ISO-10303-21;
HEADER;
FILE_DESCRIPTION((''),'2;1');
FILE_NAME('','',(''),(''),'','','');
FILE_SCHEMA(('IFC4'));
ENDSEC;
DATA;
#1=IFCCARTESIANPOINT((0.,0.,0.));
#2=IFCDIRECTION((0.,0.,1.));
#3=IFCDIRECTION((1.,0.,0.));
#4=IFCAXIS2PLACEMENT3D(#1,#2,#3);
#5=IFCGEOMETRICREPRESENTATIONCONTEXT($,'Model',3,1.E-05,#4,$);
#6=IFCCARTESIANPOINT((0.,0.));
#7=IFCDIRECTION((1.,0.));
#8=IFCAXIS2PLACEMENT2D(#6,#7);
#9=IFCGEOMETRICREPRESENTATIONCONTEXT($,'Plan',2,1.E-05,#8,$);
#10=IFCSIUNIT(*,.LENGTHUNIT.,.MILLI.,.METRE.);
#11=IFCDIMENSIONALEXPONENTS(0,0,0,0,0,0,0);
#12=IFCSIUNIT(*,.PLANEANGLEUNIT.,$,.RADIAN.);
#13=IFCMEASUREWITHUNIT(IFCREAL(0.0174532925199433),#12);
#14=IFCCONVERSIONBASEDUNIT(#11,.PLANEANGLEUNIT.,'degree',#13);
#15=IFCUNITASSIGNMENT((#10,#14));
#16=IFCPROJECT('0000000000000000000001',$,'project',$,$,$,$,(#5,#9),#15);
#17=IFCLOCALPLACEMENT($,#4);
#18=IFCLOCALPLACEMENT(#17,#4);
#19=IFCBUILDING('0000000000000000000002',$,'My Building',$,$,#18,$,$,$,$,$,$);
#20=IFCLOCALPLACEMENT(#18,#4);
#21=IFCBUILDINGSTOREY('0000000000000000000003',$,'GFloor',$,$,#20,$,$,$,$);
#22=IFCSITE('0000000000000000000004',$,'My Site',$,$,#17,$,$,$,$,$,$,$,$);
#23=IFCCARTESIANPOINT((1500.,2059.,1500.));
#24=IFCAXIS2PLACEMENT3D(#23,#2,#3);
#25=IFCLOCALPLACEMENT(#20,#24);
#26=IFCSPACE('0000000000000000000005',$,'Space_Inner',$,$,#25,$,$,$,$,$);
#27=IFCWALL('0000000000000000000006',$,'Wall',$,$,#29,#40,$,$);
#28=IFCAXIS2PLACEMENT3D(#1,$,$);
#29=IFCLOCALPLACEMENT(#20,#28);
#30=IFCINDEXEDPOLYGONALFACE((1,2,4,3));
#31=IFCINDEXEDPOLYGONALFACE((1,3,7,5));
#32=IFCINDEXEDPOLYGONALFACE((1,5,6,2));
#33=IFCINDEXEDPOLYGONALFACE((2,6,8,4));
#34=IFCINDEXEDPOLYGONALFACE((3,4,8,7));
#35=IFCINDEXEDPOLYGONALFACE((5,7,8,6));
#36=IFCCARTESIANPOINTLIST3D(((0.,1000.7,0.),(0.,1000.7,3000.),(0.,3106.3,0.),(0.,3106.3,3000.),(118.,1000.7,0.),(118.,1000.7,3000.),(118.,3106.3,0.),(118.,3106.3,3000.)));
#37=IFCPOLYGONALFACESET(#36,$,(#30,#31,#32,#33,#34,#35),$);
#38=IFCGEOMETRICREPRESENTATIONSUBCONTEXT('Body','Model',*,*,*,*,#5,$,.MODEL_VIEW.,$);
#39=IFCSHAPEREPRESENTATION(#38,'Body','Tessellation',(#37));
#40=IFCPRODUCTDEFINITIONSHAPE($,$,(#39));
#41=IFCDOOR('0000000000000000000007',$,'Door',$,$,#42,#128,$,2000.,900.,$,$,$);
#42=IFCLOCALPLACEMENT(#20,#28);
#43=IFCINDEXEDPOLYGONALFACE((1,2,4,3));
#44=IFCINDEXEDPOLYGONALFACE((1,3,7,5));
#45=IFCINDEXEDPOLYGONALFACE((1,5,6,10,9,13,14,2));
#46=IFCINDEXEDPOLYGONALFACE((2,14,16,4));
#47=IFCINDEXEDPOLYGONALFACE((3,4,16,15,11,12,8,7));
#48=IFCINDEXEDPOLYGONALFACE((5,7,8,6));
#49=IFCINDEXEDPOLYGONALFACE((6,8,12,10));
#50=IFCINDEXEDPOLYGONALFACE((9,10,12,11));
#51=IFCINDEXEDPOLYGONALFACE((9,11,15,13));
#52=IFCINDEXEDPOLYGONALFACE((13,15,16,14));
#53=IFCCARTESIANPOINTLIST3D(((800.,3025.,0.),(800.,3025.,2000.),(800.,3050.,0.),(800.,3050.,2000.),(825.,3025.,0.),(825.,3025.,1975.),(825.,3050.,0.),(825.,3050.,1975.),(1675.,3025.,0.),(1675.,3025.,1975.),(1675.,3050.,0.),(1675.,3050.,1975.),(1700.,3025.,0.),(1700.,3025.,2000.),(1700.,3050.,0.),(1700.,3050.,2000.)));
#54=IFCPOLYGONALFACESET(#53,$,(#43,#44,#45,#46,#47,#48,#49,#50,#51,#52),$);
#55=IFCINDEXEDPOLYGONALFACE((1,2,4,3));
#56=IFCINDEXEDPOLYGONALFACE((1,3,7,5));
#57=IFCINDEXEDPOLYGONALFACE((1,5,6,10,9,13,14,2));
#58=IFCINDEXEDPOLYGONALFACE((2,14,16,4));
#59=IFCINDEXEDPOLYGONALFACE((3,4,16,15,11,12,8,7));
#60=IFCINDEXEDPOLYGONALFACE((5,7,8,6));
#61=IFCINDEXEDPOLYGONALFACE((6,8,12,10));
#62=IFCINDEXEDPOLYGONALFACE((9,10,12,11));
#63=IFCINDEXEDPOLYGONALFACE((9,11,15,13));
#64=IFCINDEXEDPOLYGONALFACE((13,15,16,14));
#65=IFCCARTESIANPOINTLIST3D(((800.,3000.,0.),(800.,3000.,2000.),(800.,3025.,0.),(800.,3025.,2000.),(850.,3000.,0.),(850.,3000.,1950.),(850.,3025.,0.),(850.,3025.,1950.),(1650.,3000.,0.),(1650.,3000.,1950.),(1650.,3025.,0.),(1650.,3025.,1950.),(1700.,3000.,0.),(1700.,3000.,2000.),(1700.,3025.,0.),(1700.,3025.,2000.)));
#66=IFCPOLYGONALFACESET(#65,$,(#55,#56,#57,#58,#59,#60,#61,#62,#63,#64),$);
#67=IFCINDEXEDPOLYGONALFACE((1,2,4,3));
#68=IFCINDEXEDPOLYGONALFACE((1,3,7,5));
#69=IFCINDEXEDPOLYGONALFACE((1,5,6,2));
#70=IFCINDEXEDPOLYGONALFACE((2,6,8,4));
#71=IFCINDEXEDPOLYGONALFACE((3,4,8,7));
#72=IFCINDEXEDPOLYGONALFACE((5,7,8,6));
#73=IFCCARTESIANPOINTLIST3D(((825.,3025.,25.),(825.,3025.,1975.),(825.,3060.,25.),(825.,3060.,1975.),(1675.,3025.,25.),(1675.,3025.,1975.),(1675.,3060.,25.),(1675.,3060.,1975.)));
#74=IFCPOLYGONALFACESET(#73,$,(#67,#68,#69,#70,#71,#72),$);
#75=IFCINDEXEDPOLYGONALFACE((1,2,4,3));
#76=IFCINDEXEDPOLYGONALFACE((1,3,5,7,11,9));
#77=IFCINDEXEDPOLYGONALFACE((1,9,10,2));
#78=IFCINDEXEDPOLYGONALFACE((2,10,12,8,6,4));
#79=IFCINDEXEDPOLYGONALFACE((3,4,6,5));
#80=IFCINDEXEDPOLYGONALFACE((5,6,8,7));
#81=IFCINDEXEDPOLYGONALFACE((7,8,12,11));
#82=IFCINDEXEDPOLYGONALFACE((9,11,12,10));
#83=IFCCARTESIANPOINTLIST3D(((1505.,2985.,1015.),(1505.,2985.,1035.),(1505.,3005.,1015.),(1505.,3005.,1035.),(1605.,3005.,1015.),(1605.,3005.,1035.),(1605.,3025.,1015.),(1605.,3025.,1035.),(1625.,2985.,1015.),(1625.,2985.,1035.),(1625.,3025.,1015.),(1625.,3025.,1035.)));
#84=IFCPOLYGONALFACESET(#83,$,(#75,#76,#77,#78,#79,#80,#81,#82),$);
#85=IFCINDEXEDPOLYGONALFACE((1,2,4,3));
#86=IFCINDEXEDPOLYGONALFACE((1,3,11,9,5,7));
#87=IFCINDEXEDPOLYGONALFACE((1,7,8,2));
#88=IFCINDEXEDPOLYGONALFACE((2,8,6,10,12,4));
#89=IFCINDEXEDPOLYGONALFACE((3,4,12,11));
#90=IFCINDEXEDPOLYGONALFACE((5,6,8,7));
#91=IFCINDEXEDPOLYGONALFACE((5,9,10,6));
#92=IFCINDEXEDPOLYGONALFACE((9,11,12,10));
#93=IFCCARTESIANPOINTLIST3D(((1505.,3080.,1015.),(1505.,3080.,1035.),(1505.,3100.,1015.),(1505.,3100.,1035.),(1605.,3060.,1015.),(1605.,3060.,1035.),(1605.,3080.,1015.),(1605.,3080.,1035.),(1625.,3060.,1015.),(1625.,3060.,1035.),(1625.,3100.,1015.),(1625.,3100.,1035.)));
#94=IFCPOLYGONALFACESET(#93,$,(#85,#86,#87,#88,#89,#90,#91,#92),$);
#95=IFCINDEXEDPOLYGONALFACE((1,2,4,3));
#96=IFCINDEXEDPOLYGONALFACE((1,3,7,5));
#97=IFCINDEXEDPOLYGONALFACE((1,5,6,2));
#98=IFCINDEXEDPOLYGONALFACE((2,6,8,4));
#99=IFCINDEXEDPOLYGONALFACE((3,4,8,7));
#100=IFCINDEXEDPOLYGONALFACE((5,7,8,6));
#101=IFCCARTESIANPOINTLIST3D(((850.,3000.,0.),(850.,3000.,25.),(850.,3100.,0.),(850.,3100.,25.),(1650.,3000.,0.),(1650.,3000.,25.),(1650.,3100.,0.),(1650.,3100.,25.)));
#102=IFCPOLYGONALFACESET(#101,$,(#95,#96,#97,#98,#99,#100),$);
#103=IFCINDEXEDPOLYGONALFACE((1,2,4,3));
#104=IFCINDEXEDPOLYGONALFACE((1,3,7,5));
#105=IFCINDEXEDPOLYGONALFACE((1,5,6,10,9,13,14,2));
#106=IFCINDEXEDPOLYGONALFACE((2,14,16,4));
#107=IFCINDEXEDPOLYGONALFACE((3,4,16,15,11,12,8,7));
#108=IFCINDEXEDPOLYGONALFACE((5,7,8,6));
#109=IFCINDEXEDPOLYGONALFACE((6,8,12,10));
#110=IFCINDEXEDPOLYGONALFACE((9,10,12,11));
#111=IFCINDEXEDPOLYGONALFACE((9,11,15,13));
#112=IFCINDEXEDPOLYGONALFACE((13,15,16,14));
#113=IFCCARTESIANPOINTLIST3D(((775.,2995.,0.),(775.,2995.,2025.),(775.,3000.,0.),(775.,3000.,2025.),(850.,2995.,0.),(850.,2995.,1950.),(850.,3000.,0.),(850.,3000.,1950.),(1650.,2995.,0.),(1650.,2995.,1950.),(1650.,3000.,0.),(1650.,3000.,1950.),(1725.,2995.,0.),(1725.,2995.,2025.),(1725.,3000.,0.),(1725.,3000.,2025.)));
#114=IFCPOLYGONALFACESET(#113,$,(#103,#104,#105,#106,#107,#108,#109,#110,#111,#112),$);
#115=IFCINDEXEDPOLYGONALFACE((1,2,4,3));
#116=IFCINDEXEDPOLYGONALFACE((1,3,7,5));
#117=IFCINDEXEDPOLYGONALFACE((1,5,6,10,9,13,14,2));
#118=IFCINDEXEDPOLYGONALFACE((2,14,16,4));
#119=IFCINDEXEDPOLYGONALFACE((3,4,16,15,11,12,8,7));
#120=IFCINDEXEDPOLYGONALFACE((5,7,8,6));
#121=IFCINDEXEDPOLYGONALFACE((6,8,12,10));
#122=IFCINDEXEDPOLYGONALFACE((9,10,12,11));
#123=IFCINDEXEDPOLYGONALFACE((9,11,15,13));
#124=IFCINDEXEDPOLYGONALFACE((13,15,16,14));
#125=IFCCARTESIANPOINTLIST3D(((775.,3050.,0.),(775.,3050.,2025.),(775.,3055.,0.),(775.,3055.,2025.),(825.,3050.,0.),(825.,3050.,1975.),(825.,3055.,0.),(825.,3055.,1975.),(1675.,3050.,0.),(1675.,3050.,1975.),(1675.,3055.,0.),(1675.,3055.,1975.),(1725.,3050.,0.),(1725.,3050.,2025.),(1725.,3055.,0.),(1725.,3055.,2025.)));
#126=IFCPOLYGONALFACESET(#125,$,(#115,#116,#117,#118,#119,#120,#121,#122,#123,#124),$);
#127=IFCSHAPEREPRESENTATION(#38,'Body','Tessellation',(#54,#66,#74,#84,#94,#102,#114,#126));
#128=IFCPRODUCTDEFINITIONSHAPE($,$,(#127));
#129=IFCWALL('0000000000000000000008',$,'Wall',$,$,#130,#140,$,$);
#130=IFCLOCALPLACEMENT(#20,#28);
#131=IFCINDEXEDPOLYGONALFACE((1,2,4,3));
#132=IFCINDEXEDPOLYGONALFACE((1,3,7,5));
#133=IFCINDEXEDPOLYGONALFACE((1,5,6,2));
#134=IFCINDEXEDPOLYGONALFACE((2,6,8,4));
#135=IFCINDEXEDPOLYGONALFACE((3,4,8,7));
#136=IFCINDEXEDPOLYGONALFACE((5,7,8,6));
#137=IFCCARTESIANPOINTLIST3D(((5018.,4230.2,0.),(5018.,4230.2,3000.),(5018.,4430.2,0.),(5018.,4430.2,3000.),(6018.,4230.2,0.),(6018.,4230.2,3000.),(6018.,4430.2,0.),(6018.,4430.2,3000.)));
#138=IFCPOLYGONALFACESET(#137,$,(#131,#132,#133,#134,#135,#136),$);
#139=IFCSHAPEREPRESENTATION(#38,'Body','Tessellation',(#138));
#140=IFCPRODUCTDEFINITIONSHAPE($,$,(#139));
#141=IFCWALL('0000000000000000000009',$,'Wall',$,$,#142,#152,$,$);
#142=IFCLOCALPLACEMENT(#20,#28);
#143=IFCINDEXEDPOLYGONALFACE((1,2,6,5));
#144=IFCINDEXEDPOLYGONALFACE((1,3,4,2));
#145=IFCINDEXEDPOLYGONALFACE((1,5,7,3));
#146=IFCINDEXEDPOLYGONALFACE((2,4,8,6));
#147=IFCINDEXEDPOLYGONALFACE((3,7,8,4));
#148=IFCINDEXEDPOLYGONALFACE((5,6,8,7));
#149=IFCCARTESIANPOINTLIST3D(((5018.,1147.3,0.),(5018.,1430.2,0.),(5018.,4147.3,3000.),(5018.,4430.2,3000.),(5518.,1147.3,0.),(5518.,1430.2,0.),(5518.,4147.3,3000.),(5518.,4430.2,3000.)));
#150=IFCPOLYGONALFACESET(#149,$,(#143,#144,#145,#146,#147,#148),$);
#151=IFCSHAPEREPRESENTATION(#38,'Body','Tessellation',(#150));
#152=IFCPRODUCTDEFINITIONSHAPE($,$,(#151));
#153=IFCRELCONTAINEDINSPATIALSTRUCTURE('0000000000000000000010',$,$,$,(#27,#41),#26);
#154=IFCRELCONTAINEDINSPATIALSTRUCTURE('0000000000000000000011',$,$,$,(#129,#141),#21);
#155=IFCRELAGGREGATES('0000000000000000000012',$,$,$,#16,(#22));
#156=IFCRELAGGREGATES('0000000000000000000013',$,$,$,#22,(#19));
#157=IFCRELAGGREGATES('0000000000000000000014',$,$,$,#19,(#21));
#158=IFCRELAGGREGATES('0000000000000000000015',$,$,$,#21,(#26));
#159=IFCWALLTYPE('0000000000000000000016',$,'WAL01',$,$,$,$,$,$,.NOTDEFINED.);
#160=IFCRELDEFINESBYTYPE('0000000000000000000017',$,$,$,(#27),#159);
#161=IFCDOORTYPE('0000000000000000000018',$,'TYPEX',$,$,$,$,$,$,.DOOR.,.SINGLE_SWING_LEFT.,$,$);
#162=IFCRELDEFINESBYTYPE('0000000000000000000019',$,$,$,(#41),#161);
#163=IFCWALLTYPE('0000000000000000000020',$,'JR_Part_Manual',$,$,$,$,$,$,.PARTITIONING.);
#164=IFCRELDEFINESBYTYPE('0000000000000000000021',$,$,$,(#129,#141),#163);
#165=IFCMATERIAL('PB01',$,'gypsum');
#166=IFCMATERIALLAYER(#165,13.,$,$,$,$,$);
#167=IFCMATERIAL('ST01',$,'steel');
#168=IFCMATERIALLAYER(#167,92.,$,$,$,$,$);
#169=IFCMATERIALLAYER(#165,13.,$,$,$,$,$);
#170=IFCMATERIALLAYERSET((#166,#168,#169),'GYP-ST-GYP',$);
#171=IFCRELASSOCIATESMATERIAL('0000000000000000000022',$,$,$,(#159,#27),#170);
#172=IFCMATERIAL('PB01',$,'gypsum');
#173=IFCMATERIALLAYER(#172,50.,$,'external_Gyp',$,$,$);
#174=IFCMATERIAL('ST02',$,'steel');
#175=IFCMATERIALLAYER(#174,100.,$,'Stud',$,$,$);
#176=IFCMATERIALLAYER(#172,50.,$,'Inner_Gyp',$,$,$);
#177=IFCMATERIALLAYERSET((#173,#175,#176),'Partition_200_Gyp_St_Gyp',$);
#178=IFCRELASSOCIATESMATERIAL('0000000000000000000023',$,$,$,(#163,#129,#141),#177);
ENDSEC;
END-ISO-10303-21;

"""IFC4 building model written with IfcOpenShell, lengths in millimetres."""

from ifc_helpers import new_model, entity, si_unit, converted_unit, frame, origin_with_axes, origin_2d_with_axis, place, context, subcontext, project, spatial, line, indexed_curve, outline, extrude, shape, source, transform, mapped, material, layer, layer_set, layer_usage, type_object, type_shapes, element, save


model = new_model("IFC4")

# Units and contexts
model_context = context("Model", 3, precision=1e-05, world=origin_with_axes())
plan_context = context("Plan", 2, precision=1e-05, world=origin_2d_with_axis())
body_context_1 = subcontext(model_context, "Body", "Model", "MODEL_VIEW")
body_context_2 = subcontext(plan_context, "Body", "Plan", "PLAN_VIEW")
ifc_project = project(units=[si_unit("LENGTHUNIT", "METRE", prefix="MILLI"), converted_unit("PLANEANGLEUNIT", "degree", entity("IfcReal", 0.0174532925199433), si_unit("PLANEANGLEUNIT", "RADIAN"), dimensions=[0, 0, 0, 0, 0, 0, 0])], contexts=[model_context, plan_context])

# Site, building, storey
site_placement = place(None, origin_with_axes())
site = spatial("IfcSite", under=ifc_project, at=site_placement, Name="My Site")
building_placement = place(site_placement, origin_with_axes())
building = spatial("IfcBuilding", under=site, at=building_placement, Name="My Building")
storey_placement = place(building_placement, origin_with_axes())
storey = spatial("IfcBuildingStorey", under=building, at=storey_placement, Name="GFloor")

# Shared definitions
ifc_material_1 = material(Name="PB01", Category="gypsum")
ifc_layer_1 = layer(ifc_material_1, 13.0)
ifc_material_2 = material(Name="ST01", Category="steel")
ifc_layer_2 = layer(ifc_material_2, 92.0)
ifc_layer_3 = layer(ifc_material_1, 13.0)
ifc_layer_set_1 = layer_set([ifc_layer_1, ifc_layer_2, ifc_layer_3], Name="GYP-ST-GYP")
wall_type_1 = type_object("IfcWallType", Name="WAL01", PredefinedType="NOTDEFINED", material=ifc_layer_set_1)
door_type = type_object("IfcDoorType", Name="TYPEX", OperationType="SINGLE_SWING_LEFT", PredefinedType="DOOR")
shared_shape_1 = source(origin_with_axes(), body_context_1, "Body", "SweptSolid", [
    extrude(outline(indexed_curve([(0.0, 0.0), (0.0, 2000.0), (900.0, 2000.0), (900.0, 0.0), (875.0, 0.0), (875.0, 1975.0), (25.0, 1975.0), (25.0, 0.0)], segments=[line(1, 2, 3, 4, 5, 6, 7, 8, 1)])), frame((0.0, 25.0, 0.0), z_axis=(0.0, -1.0, 0.0), x_axis=(1.0, 0.0, 0.0)), (0.0, 0.0, -1.0), 25.0),
    extrude(outline(indexed_curve([(0.0, 0.0), (0.0, 2000.0), (900.0, 2000.0), (900.0, 0.0), (850.0, 0.0), (850.0, 1950.0), (50.0, 1950.0), (50.0, 0.0)], segments=[line(1, 2, 3, 4, 5, 6, 7, 8, 1)])), frame((0.0, 0.0, 0.0), z_axis=(0.0, -1.0, 0.0), x_axis=(1.0, 0.0, 0.0)), (0.0, 0.0, -1.0), 25.0),
    extrude(outline(indexed_curve([(0.0, 0.0), (850.0, 0.0), (850.0, 35.0), (0.0, 35.0)], segments=[line(1, 2, 3, 4, 1)])), frame((25.0, 25.0, 25.0), z_axis=(0.0, 0.0, 1.0), x_axis=(1.0, 0.0, 0.0)), (0.0, 0.0, 1.0), 1950.0),
    extrude(outline(indexed_curve([(0.0, 0.0), (0.0, -40.0), (-120.0, -40.0), (-120.0, -20.0), (-20.0, -20.0), (-20.0, 0.0)], segments=[line(1, 2, 3, 4, 5, 6, 1)])), frame((825.0, 25.0, 1015.0), z_axis=(0.0, 0.0, 1.0), x_axis=(1.0, 0.0, 0.0)), (0.0, 0.0, 1.0), 20.0),
    extrude(outline(indexed_curve([(0.0, 0.0), (0.0, 40.0), (-120.0, 40.0), (-120.0, 20.0), (-20.0, 20.0), (-20.0, 0.0)], segments=[line(1, 2, 3, 4, 5, 6, 1)])), frame((825.0, 60.0, 1015.0), z_axis=(0.0, 0.0, 1.0), x_axis=(1.0, 0.0, 0.0)), (0.0, 0.0, 1.0), 20.0),
    extrude(outline(indexed_curve([(0.0, 0.0), (800.0, 0.0), (800.0, 100.0), (0.0, 100.0)], segments=[line(1, 2, 3, 4, 1)])), frame((50.0, 0.0, 0.0), z_axis=(0.0, 0.0, 1.0), x_axis=(1.0, 0.0, 0.0)), (0.0, 0.0, 1.0), 25.0),
    extrude(outline(indexed_curve([(0.0, 0.0), (0.0, 2025.0), (950.0, 2025.0), (950.0, 0.0), (875.0, 0.0), (875.0, 1950.0), (75.0, 1950.0), (75.0, 0.0)], segments=[line(1, 2, 3, 4, 5, 6, 7, 8, 1)])), frame((-25.0, -5.0, 0.0), z_axis=(0.0, -1.0, 0.0), x_axis=(1.0, 0.0, 0.0)), (0.0, 0.0, -1.0), 5.0),
    extrude(outline(indexed_curve([(0.0, 0.0), (0.0, 2025.0), (950.0, 2025.0), (950.0, 0.0), (900.0, 0.0), (900.0, 1975.0), (50.0, 1975.0), (50.0, 0.0)], segments=[line(1, 2, 3, 4, 5, 6, 7, 8, 1)])), frame((-25.0, 50.0, 0.0), z_axis=(0.0, -1.0, 0.0), x_axis=(1.0, 0.0, 0.0)), (0.0, 0.0, -1.0), 5.0),
])
shared_shape_2 = source(origin_with_axes(), body_context_2, "Body", "Curve2D", [
    entity("IfcIndexedPolyCurve", entity("IfcCartesianPointList2D", [[0.0, 0.0], [0.0, 50.0], [25.0, 50.0], [25.0, 25.0], [50.0, 25.0], [50.0, 0.0]]), [entity("IfcLineIndex", [1, 2, 3, 4, 5, 6, 1])]),
    entity("IfcIndexedPolyCurve", entity("IfcCartesianPointList2D", [[900.0, 0.0], [900.0, 50.0], [875.0, 50.0], [875.0, 25.0], [850.0, 25.0], [850.0, 0.0]]), [entity("IfcLineIndex", [1, 2, 3, 4, 5, 6, 1])]),
    entity("IfcTrimmedCurve", entity("IfcEllipse", entity("IfcAxis2Placement2D", entity("IfcCartesianPoint", [60.0, 50.0]), entity("IfcDirection", [1.0, 0.0])), 815.0, 850.0), [entity("IfcCartesianPoint", [875.0, 50.0])], [entity("IfcCartesianPoint", [60.0, 900.0])], True, "CARTESIAN"),
    entity("IfcIndexedPolyCurve", entity("IfcCartesianPointList2D", [[25.0, 50.0], [60.0, 50.0], [60.0, 900.0], [25.0, 900.0]]), [entity("IfcLineIndex", [1, 2, 3, 4, 1])]),
])
type_shapes(door_type, [shared_shape_1, shared_shape_2])

# Shared definitions
space_1_placement = place(storey_placement, frame((1500.0, 2059.0, 1500.0), z_axis=(0.0, 0.0, 1.0), x_axis=(1.0, 0.0, 0.0)))
space_1 = spatial("IfcSpace", under=storey, at=space_1_placement, Name="Space_Inner")

# Wall
ifc_layer_usage_1 = layer_usage(ifc_layer_set_1, "AXIS2", "POSITIVE", 0.0)
wall_1_placement = place(space_1_placement, frame((-1500.0, 1047.3, -1500.0), z_axis=(0.0, 0.0, 1.0), x_axis=(0.0, -1.0, 0.0)))
element("IfcWall", 1, at=wall_1_placement, inside=space_1, type_object=wall_type_1, material=ifc_layer_usage_1, Name="Wall", context=body_context_1, shape_type="SweptSolid", body=[
    extrude(outline(indexed_curve([(0.0, 0.0), (0.0, 118.0), (2105.6, 118.0), (2105.6, 0.0), (0.0, 0.0)], self_intersect=False)), origin_with_axes(), (0.0, 0.0, 1.0), 3000.0),
])

# Door
door_1_placement = place(space_1_placement, frame((-700.0, 941.0, -1500.0), z_axis=(0.0, 0.0, 1.0), x_axis=(1.0, 0.0, 0.0)))
element("IfcDoor", 2, at=door_1_placement, inside=space_1, type_object=door_type, Name="Door", OverallHeight=2000.0, OverallWidth=900.0, shapes=[
    shape(body_context_1, "Body", "MappedRepresentation", [mapped(shared_shape_1, transform((0.0, 0.0, 0.0), x_axis=(1.0, 0.0, 0.0), y_axis=(0.0, 1.0, 0.0), z_axis=(0.0, 0.0, 1.0), scale=1.0))]),
    shape(body_context_2, "Body", "MappedRepresentation", [mapped(shared_shape_2, transform((0.0, 0.0, 0.0), x_axis=(1.0, 0.0, 0.0), y_axis=(0.0, 1.0, 0.0), z_axis=(0.0, 0.0, 1.0), scale=1.0))]),
])

# Walls
ifc_material_3 = material(Name="PB01", Category="gypsum")
ifc_layer_4 = layer(ifc_material_3, 50.0, Name="external_Gyp")
ifc_material_4 = material(Name="ST02", Category="steel")
ifc_layer_5 = layer(ifc_material_4, 100.0, Name="Stud")
ifc_layer_6 = layer(ifc_material_3, 50.0, Name="Inner_Gyp")
ifc_layer_set_2 = layer_set([ifc_layer_4, ifc_layer_5, ifc_layer_6], Name="Partition_200_Gyp_St_Gyp")
ifc_layer_usage_2 = layer_usage(ifc_layer_set_2, "AXIS2", "POSITIVE", 0.0)
wall_type_2 = type_object("IfcWallType", Name="JR_Part_Manual", PredefinedType="PARTITIONING", material=ifc_layer_set_2)
wall_2_placement = place(storey_placement, frame((5018.0, 4230.2, 0.0), z_axis=(0.0, 0.0, 1.0), x_axis=(1.0, 0.0, 0.0)))
element("IfcWall", 3, at=wall_2_placement, inside=storey, type_object=wall_type_2, material=ifc_layer_usage_2, Name="Wall", context=body_context_1, shape_type="SweptSolid", body=[
    extrude(outline(indexed_curve([(0.0, 0.0), (0.0, 200.0), (1000.0, 200.0), (1000.0, 0.0), (0.0, 0.0)], self_intersect=False)), origin_with_axes(), (0.0, 0.0, 1.0), 3000.0),
])
ifc_layer_usage_3 = layer_usage(ifc_layer_set_2, "AXIS2", "POSITIVE", 0.0)
wall_3_placement = place(storey_placement, frame((5018.0, 1147.3, 0.0), z_axis=(0.0, 0.0, 1.0), x_axis=(1.0, 0.0, 0.0)))
element("IfcWall", 4, at=wall_3_placement, inside=storey, type_object=wall_type_2, material=ifc_layer_usage_3, Name="Wall", context=body_context_1, shape_type="SweptSolid", body=[
    extrude(outline(indexed_curve([(0.0, 0.0), (0.0, 282.8), (500.0, 282.8), (500.0, 0.0), (0.0, 0.0)], self_intersect=False)), origin_with_axes(), (0.0, 0.707107, 0.707107), 4242.6),
])

save(model, "model.ifc")
